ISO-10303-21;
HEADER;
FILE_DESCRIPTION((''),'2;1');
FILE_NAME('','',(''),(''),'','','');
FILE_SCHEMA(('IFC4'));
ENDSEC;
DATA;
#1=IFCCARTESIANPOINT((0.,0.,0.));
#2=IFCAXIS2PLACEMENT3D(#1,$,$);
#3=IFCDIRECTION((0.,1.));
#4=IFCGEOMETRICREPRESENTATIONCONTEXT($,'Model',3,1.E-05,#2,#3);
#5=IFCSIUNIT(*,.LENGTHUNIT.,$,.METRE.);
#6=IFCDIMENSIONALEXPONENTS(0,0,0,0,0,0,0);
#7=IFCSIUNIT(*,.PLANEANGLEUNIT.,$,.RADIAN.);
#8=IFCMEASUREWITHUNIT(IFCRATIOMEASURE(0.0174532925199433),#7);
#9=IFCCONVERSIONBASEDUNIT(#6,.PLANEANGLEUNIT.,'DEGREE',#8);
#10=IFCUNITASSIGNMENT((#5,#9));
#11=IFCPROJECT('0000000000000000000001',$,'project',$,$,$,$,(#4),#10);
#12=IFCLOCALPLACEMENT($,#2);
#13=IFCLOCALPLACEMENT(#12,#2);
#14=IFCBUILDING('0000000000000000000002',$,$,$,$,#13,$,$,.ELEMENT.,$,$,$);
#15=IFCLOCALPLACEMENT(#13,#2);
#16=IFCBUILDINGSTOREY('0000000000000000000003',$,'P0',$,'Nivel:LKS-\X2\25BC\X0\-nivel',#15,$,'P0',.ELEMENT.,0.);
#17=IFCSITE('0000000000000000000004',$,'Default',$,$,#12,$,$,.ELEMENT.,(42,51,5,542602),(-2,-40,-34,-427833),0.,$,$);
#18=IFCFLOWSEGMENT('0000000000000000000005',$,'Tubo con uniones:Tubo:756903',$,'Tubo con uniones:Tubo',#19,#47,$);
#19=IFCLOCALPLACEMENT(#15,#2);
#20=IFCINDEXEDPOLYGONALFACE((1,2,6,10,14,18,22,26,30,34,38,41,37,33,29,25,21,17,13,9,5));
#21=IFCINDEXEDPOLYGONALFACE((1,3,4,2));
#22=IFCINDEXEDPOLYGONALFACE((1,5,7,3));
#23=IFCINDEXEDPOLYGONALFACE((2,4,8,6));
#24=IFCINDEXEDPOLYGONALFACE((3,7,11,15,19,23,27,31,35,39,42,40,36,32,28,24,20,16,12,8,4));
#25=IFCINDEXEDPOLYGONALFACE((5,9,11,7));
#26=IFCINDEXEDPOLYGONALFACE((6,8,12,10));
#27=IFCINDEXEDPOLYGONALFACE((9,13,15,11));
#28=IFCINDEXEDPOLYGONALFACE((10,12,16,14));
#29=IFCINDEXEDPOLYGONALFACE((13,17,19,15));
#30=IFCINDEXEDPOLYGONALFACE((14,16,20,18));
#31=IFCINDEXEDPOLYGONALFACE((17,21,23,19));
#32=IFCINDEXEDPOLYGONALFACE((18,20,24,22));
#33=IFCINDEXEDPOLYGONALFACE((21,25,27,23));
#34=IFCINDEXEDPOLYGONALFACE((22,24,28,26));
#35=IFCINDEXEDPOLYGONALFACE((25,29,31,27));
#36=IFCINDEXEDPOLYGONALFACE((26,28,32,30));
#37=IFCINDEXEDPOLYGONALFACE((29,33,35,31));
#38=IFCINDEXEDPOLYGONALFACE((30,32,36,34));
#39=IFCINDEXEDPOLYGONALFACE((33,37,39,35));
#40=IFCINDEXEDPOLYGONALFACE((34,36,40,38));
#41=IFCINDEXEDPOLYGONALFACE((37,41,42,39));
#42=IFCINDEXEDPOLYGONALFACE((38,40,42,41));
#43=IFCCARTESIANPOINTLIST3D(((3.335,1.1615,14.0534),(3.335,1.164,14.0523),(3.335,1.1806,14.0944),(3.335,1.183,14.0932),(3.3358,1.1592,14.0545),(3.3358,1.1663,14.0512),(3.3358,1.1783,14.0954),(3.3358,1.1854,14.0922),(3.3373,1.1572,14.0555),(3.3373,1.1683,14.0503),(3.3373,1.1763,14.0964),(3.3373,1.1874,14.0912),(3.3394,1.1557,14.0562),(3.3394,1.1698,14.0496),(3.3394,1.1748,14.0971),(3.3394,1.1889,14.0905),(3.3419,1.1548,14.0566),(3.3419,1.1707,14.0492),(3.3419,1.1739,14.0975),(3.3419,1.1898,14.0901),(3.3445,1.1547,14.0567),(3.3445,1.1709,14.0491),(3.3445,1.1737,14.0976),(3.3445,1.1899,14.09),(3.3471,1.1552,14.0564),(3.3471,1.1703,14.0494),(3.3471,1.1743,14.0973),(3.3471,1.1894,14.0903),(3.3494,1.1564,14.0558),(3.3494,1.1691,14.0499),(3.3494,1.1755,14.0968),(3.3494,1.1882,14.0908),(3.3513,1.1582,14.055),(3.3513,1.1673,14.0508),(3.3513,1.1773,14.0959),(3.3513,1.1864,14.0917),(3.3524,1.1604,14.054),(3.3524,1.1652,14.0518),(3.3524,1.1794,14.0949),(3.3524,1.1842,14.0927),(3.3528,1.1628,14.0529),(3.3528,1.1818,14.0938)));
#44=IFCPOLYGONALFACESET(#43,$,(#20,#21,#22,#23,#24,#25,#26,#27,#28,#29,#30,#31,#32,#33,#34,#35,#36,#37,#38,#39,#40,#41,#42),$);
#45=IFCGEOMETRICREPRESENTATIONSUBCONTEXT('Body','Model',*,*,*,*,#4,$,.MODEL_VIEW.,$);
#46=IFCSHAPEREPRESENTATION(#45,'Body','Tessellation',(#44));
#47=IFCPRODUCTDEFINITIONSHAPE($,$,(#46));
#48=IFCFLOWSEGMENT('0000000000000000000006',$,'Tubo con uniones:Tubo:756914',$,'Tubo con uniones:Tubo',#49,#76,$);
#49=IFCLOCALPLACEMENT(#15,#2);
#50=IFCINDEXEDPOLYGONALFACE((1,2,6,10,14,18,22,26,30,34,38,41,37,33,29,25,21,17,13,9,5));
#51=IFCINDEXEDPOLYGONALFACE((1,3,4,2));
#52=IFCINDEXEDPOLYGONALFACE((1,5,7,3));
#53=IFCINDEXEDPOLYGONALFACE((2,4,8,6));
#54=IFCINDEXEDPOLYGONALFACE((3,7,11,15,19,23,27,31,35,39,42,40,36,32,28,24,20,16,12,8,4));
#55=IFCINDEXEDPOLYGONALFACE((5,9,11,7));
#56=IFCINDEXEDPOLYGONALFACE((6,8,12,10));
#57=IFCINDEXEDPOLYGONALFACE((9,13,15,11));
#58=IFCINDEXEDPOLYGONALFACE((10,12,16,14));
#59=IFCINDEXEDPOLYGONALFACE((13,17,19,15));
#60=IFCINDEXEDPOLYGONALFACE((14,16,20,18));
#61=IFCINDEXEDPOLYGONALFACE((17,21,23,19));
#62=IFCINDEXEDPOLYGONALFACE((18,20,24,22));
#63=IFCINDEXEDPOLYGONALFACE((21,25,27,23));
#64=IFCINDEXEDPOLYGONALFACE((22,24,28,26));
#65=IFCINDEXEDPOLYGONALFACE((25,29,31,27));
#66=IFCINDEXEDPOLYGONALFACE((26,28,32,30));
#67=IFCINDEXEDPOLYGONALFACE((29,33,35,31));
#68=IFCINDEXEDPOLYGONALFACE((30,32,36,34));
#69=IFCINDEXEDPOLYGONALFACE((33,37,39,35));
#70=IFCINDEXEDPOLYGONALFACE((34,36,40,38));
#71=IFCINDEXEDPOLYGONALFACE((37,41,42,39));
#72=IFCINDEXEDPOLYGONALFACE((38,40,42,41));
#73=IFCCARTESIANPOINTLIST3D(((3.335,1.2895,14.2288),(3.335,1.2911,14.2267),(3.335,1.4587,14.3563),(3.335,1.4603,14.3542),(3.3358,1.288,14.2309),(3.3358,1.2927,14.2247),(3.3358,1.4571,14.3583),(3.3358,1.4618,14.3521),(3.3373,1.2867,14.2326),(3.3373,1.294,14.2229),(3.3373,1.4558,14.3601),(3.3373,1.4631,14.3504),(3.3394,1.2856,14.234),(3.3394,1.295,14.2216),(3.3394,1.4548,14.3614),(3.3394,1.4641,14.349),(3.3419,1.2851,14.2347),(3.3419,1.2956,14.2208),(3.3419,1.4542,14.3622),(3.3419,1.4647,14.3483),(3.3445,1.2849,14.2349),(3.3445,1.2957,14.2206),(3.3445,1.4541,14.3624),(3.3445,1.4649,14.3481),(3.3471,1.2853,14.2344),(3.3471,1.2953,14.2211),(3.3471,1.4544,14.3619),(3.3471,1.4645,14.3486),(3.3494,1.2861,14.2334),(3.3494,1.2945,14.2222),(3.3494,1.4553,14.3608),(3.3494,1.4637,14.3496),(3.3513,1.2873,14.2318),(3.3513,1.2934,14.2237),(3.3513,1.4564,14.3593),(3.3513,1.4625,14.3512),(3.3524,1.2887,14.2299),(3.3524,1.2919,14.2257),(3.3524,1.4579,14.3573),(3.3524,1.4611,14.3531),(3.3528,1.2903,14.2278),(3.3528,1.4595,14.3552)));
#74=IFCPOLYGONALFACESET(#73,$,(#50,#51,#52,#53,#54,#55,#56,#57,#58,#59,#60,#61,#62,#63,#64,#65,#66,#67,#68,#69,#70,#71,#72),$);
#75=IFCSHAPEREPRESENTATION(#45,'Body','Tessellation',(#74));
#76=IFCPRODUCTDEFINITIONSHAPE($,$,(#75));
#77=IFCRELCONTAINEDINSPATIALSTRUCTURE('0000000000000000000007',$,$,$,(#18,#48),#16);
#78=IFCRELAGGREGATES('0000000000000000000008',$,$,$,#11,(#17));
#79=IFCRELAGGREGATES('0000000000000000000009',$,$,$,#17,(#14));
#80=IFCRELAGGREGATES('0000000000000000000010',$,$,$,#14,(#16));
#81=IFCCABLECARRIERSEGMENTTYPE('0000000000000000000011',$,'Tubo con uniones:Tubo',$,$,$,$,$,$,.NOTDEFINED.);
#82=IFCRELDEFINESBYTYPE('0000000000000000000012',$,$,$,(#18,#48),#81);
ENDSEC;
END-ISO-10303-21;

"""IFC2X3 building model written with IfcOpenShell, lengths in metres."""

from ifc_helpers import new_model, entity, si_unit, converted_unit, direction, frame, frame_2d, origin, place, context, subcontext, project, spatial, circle, extrude, type_object, element, save


model = new_model("IFC2X3")

# Units and contexts
model_context = context("Model", 3, precision=1e-05, world=origin(), true_north=direction((0.0, 1.0)))
body_context = subcontext(model_context, "Body", "Model", "MODEL_VIEW")
ifc_project = project(units=[si_unit("LENGTHUNIT", "METRE"), converted_unit("PLANEANGLEUNIT", "DEGREE", entity("IfcRatioMeasure", 0.0174532925199433), si_unit("PLANEANGLEUNIT", "RADIAN"), dimensions=[0, 0, 0, 0, 0, 0, 0])], contexts=[model_context])

# Site, building, storey
site_placement = place(None, origin())
site = spatial("IfcSite", under=ifc_project, at=site_placement, Name="Default", CompositionType="ELEMENT", RefLatitude=(42, 51, 5, 542602), RefLongitude=(-2, -40, -34, -427833), RefElevation=0.0)
building_placement = place(site_placement, origin())
building = spatial("IfcBuilding", under=site, at=building_placement, CompositionType="ELEMENT")
storey_placement = place(building_placement, origin())
storey = spatial("IfcBuildingStorey", under=building, at=storey_placement, Name="P0", ObjectType="Nivel:LKS-▼-nivel", LongName="P0", CompositionType="ELEMENT", Elevation=0.0)

# Flow segments
cable_carrier_segment_type = type_object("IfcCableCarrierSegmentType", Name="Tubo con uniones:Tubo", PredefinedType="NOTDEFINED")
flow_segment_1_placement = place(storey_placement, origin())
element("IfcFlowSegment", 1, at=flow_segment_1_placement, inside=storey, type_object=cable_carrier_segment_type, Name="Tubo con uniones:Tubo:756903", ObjectType="Tubo con uniones:Tubo", context=body_context, shape_type="SweptSolid", body=[
    extrude(circle(Radius=0.009, at=frame_2d((0.0, 0.0), x_axis=(1.0, 0.0))), frame((3.3439, 1.1628, 14.0529), z_axis=(0.0, 0.422618, 0.906308), x_axis=(1.0, 0.0, 0.0)), (0.0, 0.0, 1.0), 0.0451),
])
flow_segment_2_placement = place(storey_placement, origin())
element("IfcFlowSegment", 2, at=flow_segment_2_placement, inside=storey, type_object=cable_carrier_segment_type, Name="Tubo con uniones:Tubo:756914", ObjectType="Tubo con uniones:Tubo", context=body_context, shape_type="SweptSolid", body=[
    extrude(circle(Radius=0.009, at=frame_2d((0.0, 0.0), x_axis=(1.0, 0.0))), frame((3.3439, 1.2903, 14.2278), z_axis=(0.0, 0.798636, 0.601815), x_axis=(1.0, 0.0, 0.0)), (0.0, 0.0, 1.0), 0.2118),
])

save(model, "model.ifc")
